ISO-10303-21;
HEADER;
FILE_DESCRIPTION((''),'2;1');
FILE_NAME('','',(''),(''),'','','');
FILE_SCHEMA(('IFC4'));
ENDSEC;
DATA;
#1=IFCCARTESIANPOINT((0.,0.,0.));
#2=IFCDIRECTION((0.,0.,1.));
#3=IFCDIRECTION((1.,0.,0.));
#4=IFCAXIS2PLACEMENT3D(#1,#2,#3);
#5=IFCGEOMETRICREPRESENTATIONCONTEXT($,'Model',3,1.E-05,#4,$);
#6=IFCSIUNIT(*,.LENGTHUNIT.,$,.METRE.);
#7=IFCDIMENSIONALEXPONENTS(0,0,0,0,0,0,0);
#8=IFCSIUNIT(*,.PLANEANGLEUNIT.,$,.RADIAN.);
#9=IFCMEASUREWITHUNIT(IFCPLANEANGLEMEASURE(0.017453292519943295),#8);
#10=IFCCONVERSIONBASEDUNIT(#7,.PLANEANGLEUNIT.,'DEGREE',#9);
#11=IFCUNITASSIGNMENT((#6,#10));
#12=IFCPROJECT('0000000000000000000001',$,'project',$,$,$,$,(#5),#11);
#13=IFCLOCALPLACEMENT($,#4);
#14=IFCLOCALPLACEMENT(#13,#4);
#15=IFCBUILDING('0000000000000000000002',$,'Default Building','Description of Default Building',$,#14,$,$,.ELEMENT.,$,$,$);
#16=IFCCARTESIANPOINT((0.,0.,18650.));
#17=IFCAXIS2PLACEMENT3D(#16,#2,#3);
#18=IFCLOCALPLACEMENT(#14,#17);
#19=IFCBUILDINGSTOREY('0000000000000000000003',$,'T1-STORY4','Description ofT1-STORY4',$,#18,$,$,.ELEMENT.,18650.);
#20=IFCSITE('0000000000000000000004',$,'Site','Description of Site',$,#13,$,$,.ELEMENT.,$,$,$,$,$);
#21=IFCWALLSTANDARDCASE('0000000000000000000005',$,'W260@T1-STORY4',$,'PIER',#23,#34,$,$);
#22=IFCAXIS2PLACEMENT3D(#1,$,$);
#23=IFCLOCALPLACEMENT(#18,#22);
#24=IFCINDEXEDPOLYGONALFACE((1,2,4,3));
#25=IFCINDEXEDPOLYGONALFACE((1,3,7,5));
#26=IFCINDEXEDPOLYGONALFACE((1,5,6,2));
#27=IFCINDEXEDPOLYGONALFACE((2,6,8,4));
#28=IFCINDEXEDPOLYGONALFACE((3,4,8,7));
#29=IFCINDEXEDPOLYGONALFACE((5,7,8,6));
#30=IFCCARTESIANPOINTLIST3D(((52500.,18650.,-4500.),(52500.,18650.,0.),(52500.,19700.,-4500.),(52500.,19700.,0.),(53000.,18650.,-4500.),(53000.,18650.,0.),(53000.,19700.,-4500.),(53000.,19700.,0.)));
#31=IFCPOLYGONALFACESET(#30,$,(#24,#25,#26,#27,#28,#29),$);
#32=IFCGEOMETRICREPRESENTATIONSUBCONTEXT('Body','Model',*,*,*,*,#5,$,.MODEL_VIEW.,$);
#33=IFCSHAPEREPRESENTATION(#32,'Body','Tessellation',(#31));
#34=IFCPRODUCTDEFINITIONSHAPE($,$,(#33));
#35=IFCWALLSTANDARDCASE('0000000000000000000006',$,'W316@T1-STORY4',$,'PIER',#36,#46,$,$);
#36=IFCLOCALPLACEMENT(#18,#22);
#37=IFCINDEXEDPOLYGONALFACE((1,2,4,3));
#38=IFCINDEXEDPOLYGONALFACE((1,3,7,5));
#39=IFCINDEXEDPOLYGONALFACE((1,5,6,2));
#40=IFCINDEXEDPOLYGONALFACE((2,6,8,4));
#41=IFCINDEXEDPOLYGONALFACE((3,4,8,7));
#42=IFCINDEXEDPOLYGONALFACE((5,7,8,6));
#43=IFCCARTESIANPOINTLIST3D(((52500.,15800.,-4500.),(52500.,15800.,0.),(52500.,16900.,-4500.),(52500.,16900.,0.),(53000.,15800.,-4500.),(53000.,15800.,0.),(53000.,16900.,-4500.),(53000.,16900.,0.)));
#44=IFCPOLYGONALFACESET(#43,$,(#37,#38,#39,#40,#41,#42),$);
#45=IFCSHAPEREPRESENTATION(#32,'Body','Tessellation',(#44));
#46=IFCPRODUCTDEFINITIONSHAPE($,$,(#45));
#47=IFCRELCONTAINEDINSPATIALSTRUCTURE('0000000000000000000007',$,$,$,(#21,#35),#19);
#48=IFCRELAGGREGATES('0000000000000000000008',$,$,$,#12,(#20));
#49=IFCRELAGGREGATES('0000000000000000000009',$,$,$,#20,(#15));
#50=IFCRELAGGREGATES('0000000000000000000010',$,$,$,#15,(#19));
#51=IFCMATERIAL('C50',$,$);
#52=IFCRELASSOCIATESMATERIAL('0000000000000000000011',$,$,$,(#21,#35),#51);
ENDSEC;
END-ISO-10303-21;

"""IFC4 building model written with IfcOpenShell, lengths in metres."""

from ifc_helpers import new_model, entity, si_unit, converted_unit, frame, origin_with_axes, place, context, subcontext, project, spatial, indexed_curve, outline, extrude, material, element, save


model = new_model("IFC4")

# Units and contexts
model_context = context("Model", 3, precision=1e-05, world=origin_with_axes())
body_context = subcontext(model_context, "Body", "Model", "MODEL_VIEW")
ifc_project = project(units=[si_unit("LENGTHUNIT", "METRE"), converted_unit("PLANEANGLEUNIT", "DEGREE", entity("IfcPlaneAngleMeasure", 0.017453292519943295), si_unit("PLANEANGLEUNIT", "RADIAN"), dimensions=[0, 0, 0, 0, 0, 0, 0])], contexts=[model_context])

# Site, building, storey
site_placement = place(None, origin_with_axes())
site = spatial("IfcSite", under=ifc_project, at=site_placement, Name="Site", Description="Description of Site", CompositionType="ELEMENT")
building_placement = place(site_placement, origin_with_axes())
building = spatial("IfcBuilding", under=site, at=building_placement, Name="Default Building", Description="Description of Default Building", CompositionType="ELEMENT")
storey_placement = place(building_placement, frame((0.0, 0.0, 18650.0), z_axis=(0.0, 0.0, 1.0), x_axis=(1.0, 0.0, 0.0)))
storey = spatial("IfcBuildingStorey", under=building, at=storey_placement, Name="T1-STORY4", Description="Description ofT1-STORY4", CompositionType="ELEMENT", Elevation=18650.0)

# Shared definitions
ifc_material_1 = material(Name="C50")

# Walls
wall_1_placement = place(storey_placement, frame((52750.0, 18650.0, -4500.0), z_axis=(0.0, 0.0, 1.0), x_axis=(0.0, 1.0, 0.0)))
element("IfcWallStandardCase", 1, at=wall_1_placement, inside=storey, material=ifc_material_1, Name="W260@T1-STORY4", ObjectType="PIER", context=body_context, shape_type="SweptSolid", body=[
    extrude(outline(indexed_curve([(0.0, -250.0), (0.0, 250.0), (1050.0, 250.0), (1050.0, -250.0), (0.0, -250.0)], self_intersect=False)), origin_with_axes(), (0.0, 0.0, 1.0), 4500.0),
])
wall_2_placement = place(storey_placement, frame((52750.0, 15800.0, -4500.0), z_axis=(0.0, 0.0, 1.0), x_axis=(0.0, 1.0, 0.0)))
element("IfcWallStandardCase", 2, at=wall_2_placement, inside=storey, material=ifc_material_1, Name="W316@T1-STORY4", ObjectType="PIER", context=body_context, shape_type="SweptSolid", body=[
    extrude(outline(indexed_curve([(0.0, -250.0), (0.0, 250.0), (1100.0, 250.0), (1100.0, -250.0), (0.0, -250.0)], self_intersect=False)), origin_with_axes(), (0.0, 0.0, 1.0), 4500.0),
])

save(model, "model.ifc")
